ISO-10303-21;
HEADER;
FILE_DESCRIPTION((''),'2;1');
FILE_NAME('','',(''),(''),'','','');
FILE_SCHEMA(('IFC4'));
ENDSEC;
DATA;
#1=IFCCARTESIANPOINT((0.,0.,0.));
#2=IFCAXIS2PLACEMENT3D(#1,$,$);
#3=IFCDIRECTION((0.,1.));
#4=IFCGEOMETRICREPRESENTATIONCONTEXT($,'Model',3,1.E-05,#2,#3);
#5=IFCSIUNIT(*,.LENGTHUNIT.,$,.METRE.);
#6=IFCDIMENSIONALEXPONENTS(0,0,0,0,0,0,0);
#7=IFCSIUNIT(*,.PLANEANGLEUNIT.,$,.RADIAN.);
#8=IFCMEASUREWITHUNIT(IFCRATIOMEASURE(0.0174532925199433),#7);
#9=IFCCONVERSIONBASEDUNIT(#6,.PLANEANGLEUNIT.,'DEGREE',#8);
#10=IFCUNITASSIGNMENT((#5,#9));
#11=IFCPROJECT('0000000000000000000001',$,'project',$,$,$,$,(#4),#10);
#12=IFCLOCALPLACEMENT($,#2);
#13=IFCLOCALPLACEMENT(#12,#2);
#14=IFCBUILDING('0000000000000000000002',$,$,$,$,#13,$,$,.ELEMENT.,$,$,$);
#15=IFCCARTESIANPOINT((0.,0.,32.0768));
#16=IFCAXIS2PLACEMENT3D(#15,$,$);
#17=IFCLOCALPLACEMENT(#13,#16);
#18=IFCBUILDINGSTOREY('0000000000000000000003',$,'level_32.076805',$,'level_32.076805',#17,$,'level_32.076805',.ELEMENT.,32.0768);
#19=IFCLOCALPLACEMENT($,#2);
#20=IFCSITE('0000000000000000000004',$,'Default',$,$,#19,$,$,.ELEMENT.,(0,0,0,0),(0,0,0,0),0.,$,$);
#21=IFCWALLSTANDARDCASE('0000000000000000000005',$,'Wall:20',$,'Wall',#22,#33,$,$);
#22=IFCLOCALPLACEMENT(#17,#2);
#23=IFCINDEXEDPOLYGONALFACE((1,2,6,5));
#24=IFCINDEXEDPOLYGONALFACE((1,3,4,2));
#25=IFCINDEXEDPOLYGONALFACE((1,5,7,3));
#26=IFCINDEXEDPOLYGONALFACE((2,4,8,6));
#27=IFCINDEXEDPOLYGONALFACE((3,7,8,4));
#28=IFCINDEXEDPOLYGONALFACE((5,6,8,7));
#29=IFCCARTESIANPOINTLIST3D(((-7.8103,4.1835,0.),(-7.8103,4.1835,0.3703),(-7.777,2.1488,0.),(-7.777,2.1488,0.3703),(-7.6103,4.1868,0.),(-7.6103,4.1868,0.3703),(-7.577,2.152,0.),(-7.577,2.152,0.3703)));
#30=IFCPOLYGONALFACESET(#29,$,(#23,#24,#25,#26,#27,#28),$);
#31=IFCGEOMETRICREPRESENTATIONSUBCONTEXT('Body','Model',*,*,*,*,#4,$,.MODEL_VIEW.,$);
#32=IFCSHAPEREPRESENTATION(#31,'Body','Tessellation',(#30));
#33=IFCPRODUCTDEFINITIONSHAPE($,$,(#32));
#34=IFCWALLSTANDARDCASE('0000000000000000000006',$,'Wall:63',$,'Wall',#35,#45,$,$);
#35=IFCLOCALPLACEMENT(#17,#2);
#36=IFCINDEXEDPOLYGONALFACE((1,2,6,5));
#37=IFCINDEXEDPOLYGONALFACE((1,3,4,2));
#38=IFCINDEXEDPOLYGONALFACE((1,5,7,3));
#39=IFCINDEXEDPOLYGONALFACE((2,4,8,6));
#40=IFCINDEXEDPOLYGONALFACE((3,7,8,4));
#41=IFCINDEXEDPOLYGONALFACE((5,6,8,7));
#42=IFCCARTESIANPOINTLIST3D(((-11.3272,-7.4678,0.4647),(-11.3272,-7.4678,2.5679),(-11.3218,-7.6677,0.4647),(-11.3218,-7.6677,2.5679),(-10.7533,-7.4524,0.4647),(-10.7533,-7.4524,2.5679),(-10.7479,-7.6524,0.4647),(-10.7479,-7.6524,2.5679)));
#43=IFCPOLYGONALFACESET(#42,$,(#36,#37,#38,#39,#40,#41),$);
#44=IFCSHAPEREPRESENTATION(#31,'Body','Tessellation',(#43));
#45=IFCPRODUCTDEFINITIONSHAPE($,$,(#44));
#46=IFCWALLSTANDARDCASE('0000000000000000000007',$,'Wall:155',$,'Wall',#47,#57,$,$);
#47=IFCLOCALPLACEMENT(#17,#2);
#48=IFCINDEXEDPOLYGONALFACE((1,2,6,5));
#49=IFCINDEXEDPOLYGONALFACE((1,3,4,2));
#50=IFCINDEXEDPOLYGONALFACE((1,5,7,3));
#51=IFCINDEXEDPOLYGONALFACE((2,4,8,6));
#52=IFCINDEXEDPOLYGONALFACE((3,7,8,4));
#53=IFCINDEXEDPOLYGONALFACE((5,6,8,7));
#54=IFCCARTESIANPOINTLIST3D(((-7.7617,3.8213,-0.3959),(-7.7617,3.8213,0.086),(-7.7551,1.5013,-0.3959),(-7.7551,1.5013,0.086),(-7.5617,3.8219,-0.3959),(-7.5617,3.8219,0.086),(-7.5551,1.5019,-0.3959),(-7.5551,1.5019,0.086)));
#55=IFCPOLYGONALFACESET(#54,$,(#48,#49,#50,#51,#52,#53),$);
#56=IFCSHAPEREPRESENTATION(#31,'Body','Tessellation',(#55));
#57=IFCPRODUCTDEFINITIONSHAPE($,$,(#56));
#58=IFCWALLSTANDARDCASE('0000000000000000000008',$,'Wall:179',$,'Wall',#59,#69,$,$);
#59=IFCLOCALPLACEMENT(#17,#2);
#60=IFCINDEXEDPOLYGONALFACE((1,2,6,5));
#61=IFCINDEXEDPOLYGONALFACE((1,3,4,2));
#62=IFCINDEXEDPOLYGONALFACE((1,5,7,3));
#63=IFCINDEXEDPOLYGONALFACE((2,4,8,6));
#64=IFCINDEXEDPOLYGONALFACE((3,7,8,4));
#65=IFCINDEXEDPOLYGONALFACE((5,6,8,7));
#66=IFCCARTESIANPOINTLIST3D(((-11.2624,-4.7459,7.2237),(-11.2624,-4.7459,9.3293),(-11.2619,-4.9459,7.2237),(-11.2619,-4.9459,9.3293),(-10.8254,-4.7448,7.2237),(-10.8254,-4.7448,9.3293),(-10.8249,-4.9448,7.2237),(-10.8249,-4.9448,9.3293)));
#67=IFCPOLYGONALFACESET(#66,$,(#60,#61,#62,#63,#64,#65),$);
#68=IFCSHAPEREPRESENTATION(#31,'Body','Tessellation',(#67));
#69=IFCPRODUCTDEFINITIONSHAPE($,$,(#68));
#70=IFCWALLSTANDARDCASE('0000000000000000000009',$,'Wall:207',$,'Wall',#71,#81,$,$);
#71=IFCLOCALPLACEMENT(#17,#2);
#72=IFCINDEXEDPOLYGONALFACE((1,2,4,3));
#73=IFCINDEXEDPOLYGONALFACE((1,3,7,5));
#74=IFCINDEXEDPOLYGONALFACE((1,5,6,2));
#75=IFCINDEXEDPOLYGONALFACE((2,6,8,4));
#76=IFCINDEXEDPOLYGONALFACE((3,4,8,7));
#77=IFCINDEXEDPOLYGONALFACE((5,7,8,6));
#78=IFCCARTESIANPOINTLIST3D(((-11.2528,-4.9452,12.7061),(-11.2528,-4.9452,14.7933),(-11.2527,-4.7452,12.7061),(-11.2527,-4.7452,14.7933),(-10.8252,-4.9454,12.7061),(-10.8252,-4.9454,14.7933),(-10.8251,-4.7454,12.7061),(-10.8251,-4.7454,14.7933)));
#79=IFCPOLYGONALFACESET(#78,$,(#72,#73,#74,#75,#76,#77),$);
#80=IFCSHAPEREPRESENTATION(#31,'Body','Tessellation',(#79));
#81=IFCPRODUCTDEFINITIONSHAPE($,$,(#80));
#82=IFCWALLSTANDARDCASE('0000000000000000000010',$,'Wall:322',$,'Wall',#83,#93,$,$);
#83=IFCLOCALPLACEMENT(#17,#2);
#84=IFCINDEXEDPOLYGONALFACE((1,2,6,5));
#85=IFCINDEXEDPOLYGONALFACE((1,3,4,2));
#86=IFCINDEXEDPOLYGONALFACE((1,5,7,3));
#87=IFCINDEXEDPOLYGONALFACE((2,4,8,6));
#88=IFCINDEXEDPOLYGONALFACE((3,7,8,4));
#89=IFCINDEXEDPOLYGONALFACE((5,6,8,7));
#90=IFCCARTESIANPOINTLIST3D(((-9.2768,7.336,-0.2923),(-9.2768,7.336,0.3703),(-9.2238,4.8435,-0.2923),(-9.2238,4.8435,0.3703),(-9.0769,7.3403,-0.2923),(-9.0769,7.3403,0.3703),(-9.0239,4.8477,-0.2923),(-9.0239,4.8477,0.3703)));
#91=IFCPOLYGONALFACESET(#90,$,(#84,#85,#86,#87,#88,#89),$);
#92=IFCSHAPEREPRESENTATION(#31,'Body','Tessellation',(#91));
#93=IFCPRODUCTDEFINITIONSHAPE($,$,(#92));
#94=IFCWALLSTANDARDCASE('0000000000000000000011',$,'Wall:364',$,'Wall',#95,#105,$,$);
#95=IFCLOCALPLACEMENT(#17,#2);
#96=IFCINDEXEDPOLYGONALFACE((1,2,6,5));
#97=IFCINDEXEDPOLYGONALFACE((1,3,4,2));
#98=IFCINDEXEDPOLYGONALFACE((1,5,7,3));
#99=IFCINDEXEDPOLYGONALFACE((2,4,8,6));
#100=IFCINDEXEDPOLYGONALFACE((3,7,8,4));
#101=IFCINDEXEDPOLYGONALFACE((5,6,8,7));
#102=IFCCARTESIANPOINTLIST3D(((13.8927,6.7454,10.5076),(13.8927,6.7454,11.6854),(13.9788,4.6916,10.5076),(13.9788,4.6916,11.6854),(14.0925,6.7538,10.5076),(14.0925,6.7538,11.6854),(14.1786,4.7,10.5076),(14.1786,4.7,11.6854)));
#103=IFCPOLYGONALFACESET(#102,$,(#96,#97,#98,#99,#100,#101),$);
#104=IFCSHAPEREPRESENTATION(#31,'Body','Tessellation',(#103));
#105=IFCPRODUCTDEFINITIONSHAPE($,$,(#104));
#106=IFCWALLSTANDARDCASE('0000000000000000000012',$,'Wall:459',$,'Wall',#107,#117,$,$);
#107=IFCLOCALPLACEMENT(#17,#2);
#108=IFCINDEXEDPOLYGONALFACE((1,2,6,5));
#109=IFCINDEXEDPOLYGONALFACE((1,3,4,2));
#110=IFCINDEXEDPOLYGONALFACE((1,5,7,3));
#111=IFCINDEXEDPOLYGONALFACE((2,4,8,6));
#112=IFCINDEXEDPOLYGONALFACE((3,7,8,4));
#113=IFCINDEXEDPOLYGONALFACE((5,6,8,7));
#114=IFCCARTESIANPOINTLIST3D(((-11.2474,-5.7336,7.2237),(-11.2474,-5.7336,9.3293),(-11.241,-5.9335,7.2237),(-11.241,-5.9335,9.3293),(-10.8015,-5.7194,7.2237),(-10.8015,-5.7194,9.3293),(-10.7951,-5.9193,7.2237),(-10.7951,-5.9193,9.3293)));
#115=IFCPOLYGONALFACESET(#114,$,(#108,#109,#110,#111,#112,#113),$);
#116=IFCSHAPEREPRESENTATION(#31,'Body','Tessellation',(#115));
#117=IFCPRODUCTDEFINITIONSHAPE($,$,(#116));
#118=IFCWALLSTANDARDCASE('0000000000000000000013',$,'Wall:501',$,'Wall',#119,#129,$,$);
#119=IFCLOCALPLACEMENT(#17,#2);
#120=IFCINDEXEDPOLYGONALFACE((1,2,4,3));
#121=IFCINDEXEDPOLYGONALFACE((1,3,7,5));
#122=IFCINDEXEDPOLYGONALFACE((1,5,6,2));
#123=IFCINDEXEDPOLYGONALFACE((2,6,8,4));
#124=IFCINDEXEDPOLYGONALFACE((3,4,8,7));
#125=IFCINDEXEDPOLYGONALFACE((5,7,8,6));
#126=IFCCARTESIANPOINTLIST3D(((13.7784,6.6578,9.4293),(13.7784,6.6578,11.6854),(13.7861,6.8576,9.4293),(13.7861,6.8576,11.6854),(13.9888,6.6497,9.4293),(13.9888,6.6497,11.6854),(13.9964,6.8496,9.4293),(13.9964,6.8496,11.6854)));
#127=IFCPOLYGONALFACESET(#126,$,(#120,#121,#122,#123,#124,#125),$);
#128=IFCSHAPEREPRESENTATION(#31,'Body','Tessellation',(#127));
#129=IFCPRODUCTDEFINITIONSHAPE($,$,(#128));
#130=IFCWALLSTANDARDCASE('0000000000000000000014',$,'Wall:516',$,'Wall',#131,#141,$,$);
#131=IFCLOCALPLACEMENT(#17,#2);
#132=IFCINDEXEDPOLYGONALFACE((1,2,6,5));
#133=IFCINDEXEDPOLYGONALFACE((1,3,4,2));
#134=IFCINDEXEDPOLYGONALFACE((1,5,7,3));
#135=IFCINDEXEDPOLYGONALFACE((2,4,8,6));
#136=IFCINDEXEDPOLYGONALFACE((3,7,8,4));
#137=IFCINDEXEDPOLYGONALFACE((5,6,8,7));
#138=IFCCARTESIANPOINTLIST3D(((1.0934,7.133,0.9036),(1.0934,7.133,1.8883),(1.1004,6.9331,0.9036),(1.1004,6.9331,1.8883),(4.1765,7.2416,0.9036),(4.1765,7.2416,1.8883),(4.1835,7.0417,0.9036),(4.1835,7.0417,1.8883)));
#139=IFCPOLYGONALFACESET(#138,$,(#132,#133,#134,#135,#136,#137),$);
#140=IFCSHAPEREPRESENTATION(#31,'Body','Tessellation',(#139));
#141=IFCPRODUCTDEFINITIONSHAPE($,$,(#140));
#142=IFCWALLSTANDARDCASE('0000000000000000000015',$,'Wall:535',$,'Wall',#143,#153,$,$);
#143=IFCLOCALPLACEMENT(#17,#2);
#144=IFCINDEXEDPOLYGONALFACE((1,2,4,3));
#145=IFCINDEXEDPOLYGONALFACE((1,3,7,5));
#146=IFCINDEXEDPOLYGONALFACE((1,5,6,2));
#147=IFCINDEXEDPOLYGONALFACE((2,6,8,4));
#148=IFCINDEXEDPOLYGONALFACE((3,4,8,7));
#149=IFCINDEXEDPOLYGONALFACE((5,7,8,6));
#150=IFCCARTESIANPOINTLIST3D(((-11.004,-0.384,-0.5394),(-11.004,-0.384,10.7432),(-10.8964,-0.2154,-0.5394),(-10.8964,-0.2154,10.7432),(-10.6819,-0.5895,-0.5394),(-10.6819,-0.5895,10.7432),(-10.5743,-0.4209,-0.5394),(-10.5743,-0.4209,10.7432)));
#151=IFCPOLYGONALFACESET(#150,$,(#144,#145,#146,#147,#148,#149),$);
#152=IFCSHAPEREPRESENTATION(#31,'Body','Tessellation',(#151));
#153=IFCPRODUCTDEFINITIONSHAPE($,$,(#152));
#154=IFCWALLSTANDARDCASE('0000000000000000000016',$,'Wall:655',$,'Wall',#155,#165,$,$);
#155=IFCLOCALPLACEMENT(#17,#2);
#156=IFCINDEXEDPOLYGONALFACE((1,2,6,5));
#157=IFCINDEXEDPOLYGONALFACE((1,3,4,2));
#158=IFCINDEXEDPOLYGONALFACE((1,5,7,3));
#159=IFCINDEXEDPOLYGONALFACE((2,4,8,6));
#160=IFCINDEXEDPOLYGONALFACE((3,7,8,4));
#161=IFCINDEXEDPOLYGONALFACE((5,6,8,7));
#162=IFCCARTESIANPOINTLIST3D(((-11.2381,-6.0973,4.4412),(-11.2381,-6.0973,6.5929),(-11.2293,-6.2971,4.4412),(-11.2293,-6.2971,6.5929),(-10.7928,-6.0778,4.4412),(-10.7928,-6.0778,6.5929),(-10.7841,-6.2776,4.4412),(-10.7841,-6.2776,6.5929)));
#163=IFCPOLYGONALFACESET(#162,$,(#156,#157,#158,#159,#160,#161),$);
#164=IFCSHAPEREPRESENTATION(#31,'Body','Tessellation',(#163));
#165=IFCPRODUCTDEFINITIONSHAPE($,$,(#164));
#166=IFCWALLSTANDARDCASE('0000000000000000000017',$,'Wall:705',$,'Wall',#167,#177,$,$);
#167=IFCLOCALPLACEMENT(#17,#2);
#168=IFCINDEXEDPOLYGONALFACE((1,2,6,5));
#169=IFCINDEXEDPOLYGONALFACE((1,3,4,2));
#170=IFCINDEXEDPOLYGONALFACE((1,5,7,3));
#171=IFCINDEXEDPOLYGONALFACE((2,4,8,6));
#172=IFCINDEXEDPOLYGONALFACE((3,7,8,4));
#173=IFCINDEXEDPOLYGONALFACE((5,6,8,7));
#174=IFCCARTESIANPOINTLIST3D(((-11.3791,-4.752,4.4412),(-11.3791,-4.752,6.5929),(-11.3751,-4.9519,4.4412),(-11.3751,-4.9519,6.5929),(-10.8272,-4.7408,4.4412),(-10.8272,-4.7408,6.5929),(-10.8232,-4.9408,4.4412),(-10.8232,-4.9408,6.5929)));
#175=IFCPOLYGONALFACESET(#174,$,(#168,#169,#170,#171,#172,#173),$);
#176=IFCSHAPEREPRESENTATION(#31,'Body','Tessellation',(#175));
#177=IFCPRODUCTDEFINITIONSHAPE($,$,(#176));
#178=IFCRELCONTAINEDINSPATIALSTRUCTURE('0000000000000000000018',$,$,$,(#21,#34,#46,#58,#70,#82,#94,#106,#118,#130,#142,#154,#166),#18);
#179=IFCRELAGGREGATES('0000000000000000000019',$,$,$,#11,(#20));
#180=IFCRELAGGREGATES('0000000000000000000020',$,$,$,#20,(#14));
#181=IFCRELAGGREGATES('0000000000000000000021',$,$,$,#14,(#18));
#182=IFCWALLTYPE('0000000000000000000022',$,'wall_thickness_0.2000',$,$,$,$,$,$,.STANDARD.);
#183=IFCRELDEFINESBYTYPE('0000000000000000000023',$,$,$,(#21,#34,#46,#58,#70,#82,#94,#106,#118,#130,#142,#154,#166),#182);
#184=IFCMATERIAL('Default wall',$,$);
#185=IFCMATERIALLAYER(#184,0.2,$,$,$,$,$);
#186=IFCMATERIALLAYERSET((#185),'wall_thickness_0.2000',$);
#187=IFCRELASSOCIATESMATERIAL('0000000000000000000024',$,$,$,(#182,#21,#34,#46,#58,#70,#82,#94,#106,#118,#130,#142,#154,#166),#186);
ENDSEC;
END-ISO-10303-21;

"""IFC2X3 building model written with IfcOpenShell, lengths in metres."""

from ifc_helpers import new_model, entity, si_unit, converted_unit, direction, frame, origin, place, context, subcontext, project, spatial, polyline, outline, extrude, material, layer, layer_set, layer_usage, type_object, element, save


model = new_model("IFC2X3")

# Units and contexts
model_context = context("Model", 3, precision=1e-05, world=origin(), true_north=direction((0.0, 1.0)))
body_context = subcontext(model_context, "Body", "Model", "MODEL_VIEW")
ifc_project = project(units=[si_unit("LENGTHUNIT", "METRE"), converted_unit("PLANEANGLEUNIT", "DEGREE", entity("IfcRatioMeasure", 0.0174532925199433), si_unit("PLANEANGLEUNIT", "RADIAN"), dimensions=[0, 0, 0, 0, 0, 0, 0])], contexts=[model_context])

# Site, building, storey
site_placement = place(None, origin())
site = spatial("IfcSite", under=ifc_project, at=site_placement, Name="Default", CompositionType="ELEMENT", RefLatitude=(0, 0, 0, 0), RefLongitude=(0, 0, 0, 0), RefElevation=0.0)
placement_1 = place(None, origin())
building_placement = place(placement_1, origin())
building = spatial("IfcBuilding", under=site, at=building_placement, CompositionType="ELEMENT")
storey_placement = place(building_placement, frame((0.0, 0.0, 32.0768)))
storey = spatial("IfcBuildingStorey", under=building, at=storey_placement, Name="level_32.076805", ObjectType="level_32.076805", LongName="level_32.076805", CompositionType="ELEMENT", Elevation=32.0768)

# Walls
ifc_material = material(Name="Default wall")
ifc_layer = layer(ifc_material, 0.2)
ifc_layer_set = layer_set([ifc_layer], Name="wall_thickness_0.2000")
ifc_layer_usage = layer_usage(ifc_layer_set, "AXIS2", "POSITIVE", -0.1)
wall_type = type_object("IfcWallType", Name="wall_thickness_0.2000", PredefinedType="STANDARD", material=ifc_layer_set)
wall_1_placement = place(storey_placement, frame((-7.677, 2.1504, 0.0), z_axis=(0.0, 0.0, 1.0), x_axis=(-0.016355, 0.999866, 0.0)))
element("IfcWallStandardCase", 1, at=wall_1_placement, inside=storey, type_object=wall_type, material=ifc_layer_usage, Name="Wall:20", ObjectType="Wall", context=body_context, shape_type="SweptSolid", body=[
    extrude(outline(polyline([(2.035, -0.1), (2.035, 0.1), (0.0, 0.1), (0.0, -0.1), (2.035, -0.1)])), origin(), (0.0, 0.0, 1.0), 0.3703),
])
placement_2 = place(building_placement, frame((0.0, 0.0, 32.5415)))
wall_2_placement = place(placement_2, frame((-10.7506, -7.5524, 0.0), z_axis=(0.0, 0.0, 1.0), x_axis=(-0.999643, -0.026734, 0.0)))
element("IfcWallStandardCase", 2, at=wall_2_placement, inside=storey, type_object=wall_type, material=ifc_layer_usage, Name="Wall:63", ObjectType="Wall", context=body_context, shape_type="SweptSolid", body=[
    extrude(outline(polyline([(0.5741, -0.1), (0.5741, 0.1), (0.0, 0.1), (0.0, -0.1), (0.5741, -0.1)])), origin(), (0.0, 0.0, 1.0), 2.1031),
])
placement_3 = place(building_placement, frame((0.0, 0.0, 31.6809)))
wall_3_placement = place(placement_3, frame((-7.6617, 3.8216, 0.0), z_axis=(0.0, 0.0, 1.0), x_axis=(0.002852, -0.999996, 0.0)))
element("IfcWallStandardCase", 3, at=wall_3_placement, inside=storey, type_object=wall_type, material=ifc_layer_usage, Name="Wall:155", ObjectType="Wall", context=body_context, shape_type="SweptSolid", body=[
    extrude(outline(polyline([(2.32, -0.1), (2.32, 0.1), (0.0, 0.1), (0.0, -0.1), (2.32, -0.1)])), origin(), (0.0, 0.0, 1.0), 0.4819),
])
placement_4 = place(building_placement, frame((0.0, 0.0, 39.3005)))
wall_4_placement = place(placement_4, frame((-10.8251, -4.8448, 0.0), z_axis=(0.0, 0.0, 1.0), x_axis=(-0.999997, -0.002545, 0.0)))
element("IfcWallStandardCase", 4, at=wall_4_placement, inside=storey, type_object=wall_type, material=ifc_layer_usage, Name="Wall:179", ObjectType="Wall", context=body_context, shape_type="SweptSolid", body=[
    extrude(outline(polyline([(0.4371, -0.1), (0.4371, 0.1), (0.0, 0.1), (0.0, -0.1), (0.4371, -0.1)])), origin(), (0.0, 0.0, 1.0), 2.1056),
])
placement_5 = place(building_placement, frame((0.0, 0.0, 44.7829)))
wall_5_placement = place(placement_5, frame((-10.8251, -4.8454, 0.0), z_axis=(0.0, 0.0, 1.0), x_axis=(-1.0, 0.000589, 0.0)))
element("IfcWallStandardCase", 5, at=wall_5_placement, inside=storey, type_object=wall_type, material=ifc_layer_usage, Name="Wall:207", ObjectType="Wall", context=body_context, shape_type="SweptSolid", body=[
    extrude(outline(polyline([(0.4276, -0.1), (0.4276, 0.1), (0.0, 0.1), (0.0, -0.1), (0.4276, -0.1)])), origin(), (0.0, 0.0, 1.0), 2.0872),
])
placement_6 = place(building_placement, frame((0.0, 0.0, 31.7845)))
wall_6_placement = place(placement_6, frame((-9.1238, 4.8456, 0.0), z_axis=(0.0, 0.0, 1.0), x_axis=(-0.021271, 0.999774, 0.0)))
element("IfcWallStandardCase", 6, at=wall_6_placement, inside=storey, type_object=wall_type, material=ifc_layer_usage, Name="Wall:322", ObjectType="Wall", context=body_context, shape_type="SweptSolid", body=[
    extrude(outline(polyline([(2.4931, -0.1), (2.4931, 0.1), (0.0, 0.1), (0.0, -0.1), (2.4931, -0.1)])), origin(), (0.0, 0.0, 1.0), 0.6626),
])
placement_7 = place(building_placement, frame((0.0, 0.0, 42.5844)))
wall_7_placement = place(placement_7, frame((14.0787, 4.6958, 0.0), z_axis=(0.0, 0.0, 1.0), x_axis=(-0.041871, 0.999123, 0.0)))
element("IfcWallStandardCase", 7, at=wall_7_placement, inside=storey, type_object=wall_type, material=ifc_layer_usage, Name="Wall:364", ObjectType="Wall", context=body_context, shape_type="SweptSolid", body=[
    extrude(outline(polyline([(2.0557, -0.1), (2.0557, 0.1), (0.0, 0.1), (0.0, -0.1), (2.0557, -0.1)])), origin(), (0.0, 0.0, 1.0), 1.1778),
])
placement_8 = place(building_placement, frame((0.0, 0.0, 39.3005)))
wall_8_placement = place(placement_8, frame((-10.7983, -5.8193, 0.0), z_axis=(0.0, 0.0, 1.0), x_axis=(-0.999493, -0.031831, 0.0)))
element("IfcWallStandardCase", 8, at=wall_8_placement, inside=storey, type_object=wall_type, material=ifc_layer_usage, Name="Wall:459", ObjectType="Wall", context=body_context, shape_type="SweptSolid", body=[
    extrude(outline(polyline([(0.4461, -0.1), (0.4461, 0.1), (0.0, 0.1), (0.0, -0.1), (0.4461, -0.1)])), origin(), (0.0, 0.0, 1.0), 2.1056),
])
placement_9 = place(building_placement, frame((0.0, 0.0, 41.5061)))
wall_9_placement = place(placement_9, frame((13.9926, 6.7496, 0.0), z_axis=(0.0, 0.0, 1.0), x_axis=(-0.99926, 0.038459, 0.0)))
element("IfcWallStandardCase", 9, at=wall_9_placement, inside=storey, type_object=wall_type, material=ifc_layer_usage, Name="Wall:501", ObjectType="Wall", context=body_context, shape_type="SweptSolid", body=[
    extrude(outline(polyline([(0.2105, -0.1), (0.2105, 0.1), (0.0, 0.1), (0.0, -0.1), (0.2105, -0.1)])), origin(), (0.0, 0.0, 1.0), 2.2561),
])
placement_10 = place(building_placement, frame((0.0, 0.0, 32.9804)))
wall_10_placement = place(placement_10, frame((1.0969, 7.0331, 0.0), z_axis=(0.0, 0.0, 1.0), x_axis=(0.999381, 0.035193, 0.0)))
element("IfcWallStandardCase", 10, at=wall_10_placement, inside=storey, type_object=wall_type, material=ifc_layer_usage, Name="Wall:516", ObjectType="Wall", context=body_context, shape_type="SweptSolid", body=[
    extrude(outline(polyline([(3.085, -0.1), (3.085, 0.1), (0.0, 0.1), (0.0, -0.1), (3.085, -0.1)])), origin(), (0.0, 0.0, 1.0), 0.9847),
])
placement_11 = place(building_placement, frame((0.0, 0.0, 31.5374)))
wall_11_placement = place(placement_11, frame((-10.6281, -0.5052, 0.0), z_axis=(0.0, 0.0, 1.0), x_axis=(-0.842971, 0.53796, 0.0)))
element("IfcWallStandardCase", 11, at=wall_11_placement, inside=storey, type_object=wall_type, material=ifc_layer_usage, Name="Wall:535", ObjectType="Wall", context=body_context, shape_type="SweptSolid", body=[
    extrude(outline(polyline([(0.3821, -0.1), (0.3821, 0.1), (0.0, 0.1), (0.0, -0.1), (0.3821, -0.1)])), origin(), (0.0, 0.0, 1.0), 11.2825),
])
placement_12 = place(building_placement, frame((0.0, 0.0, 36.518)))
wall_12_placement = place(placement_12, frame((-10.7884, -6.1777, 0.0), z_axis=(0.0, 0.0, 1.0), x_axis=(-0.999042, -0.043759, 0.0)))
element("IfcWallStandardCase", 12, at=wall_12_placement, inside=storey, type_object=wall_type, material=ifc_layer_usage, Name="Wall:655", ObjectType="Wall", context=body_context, shape_type="SweptSolid", body=[
    extrude(outline(polyline([(0.4457, -0.1), (0.4457, 0.1), (0.0, 0.1), (0.0, -0.1), (0.4457, -0.1)])), origin(), (0.0, 0.0, 1.0), 2.1518),
])
placement_13 = place(building_placement, frame((0.0, 0.0, 36.518)))
wall_13_placement = place(placement_13, frame((-10.8252, -4.8408, 0.0), z_axis=(0.0, 0.0, 1.0), x_axis=(-0.999797, -0.02013, 0.0)))
element("IfcWallStandardCase", 13, at=wall_13_placement, inside=storey, type_object=wall_type, material=ifc_layer_usage, Name="Wall:705", ObjectType="Wall", context=body_context, shape_type="SweptSolid", body=[
    extrude(outline(polyline([(0.552, -0.1), (0.552, 0.1), (0.0, 0.1), (0.0, -0.1), (0.552, -0.1)])), origin(), (0.0, 0.0, 1.0), 2.1518),
])

save(model, "model.ifc")
